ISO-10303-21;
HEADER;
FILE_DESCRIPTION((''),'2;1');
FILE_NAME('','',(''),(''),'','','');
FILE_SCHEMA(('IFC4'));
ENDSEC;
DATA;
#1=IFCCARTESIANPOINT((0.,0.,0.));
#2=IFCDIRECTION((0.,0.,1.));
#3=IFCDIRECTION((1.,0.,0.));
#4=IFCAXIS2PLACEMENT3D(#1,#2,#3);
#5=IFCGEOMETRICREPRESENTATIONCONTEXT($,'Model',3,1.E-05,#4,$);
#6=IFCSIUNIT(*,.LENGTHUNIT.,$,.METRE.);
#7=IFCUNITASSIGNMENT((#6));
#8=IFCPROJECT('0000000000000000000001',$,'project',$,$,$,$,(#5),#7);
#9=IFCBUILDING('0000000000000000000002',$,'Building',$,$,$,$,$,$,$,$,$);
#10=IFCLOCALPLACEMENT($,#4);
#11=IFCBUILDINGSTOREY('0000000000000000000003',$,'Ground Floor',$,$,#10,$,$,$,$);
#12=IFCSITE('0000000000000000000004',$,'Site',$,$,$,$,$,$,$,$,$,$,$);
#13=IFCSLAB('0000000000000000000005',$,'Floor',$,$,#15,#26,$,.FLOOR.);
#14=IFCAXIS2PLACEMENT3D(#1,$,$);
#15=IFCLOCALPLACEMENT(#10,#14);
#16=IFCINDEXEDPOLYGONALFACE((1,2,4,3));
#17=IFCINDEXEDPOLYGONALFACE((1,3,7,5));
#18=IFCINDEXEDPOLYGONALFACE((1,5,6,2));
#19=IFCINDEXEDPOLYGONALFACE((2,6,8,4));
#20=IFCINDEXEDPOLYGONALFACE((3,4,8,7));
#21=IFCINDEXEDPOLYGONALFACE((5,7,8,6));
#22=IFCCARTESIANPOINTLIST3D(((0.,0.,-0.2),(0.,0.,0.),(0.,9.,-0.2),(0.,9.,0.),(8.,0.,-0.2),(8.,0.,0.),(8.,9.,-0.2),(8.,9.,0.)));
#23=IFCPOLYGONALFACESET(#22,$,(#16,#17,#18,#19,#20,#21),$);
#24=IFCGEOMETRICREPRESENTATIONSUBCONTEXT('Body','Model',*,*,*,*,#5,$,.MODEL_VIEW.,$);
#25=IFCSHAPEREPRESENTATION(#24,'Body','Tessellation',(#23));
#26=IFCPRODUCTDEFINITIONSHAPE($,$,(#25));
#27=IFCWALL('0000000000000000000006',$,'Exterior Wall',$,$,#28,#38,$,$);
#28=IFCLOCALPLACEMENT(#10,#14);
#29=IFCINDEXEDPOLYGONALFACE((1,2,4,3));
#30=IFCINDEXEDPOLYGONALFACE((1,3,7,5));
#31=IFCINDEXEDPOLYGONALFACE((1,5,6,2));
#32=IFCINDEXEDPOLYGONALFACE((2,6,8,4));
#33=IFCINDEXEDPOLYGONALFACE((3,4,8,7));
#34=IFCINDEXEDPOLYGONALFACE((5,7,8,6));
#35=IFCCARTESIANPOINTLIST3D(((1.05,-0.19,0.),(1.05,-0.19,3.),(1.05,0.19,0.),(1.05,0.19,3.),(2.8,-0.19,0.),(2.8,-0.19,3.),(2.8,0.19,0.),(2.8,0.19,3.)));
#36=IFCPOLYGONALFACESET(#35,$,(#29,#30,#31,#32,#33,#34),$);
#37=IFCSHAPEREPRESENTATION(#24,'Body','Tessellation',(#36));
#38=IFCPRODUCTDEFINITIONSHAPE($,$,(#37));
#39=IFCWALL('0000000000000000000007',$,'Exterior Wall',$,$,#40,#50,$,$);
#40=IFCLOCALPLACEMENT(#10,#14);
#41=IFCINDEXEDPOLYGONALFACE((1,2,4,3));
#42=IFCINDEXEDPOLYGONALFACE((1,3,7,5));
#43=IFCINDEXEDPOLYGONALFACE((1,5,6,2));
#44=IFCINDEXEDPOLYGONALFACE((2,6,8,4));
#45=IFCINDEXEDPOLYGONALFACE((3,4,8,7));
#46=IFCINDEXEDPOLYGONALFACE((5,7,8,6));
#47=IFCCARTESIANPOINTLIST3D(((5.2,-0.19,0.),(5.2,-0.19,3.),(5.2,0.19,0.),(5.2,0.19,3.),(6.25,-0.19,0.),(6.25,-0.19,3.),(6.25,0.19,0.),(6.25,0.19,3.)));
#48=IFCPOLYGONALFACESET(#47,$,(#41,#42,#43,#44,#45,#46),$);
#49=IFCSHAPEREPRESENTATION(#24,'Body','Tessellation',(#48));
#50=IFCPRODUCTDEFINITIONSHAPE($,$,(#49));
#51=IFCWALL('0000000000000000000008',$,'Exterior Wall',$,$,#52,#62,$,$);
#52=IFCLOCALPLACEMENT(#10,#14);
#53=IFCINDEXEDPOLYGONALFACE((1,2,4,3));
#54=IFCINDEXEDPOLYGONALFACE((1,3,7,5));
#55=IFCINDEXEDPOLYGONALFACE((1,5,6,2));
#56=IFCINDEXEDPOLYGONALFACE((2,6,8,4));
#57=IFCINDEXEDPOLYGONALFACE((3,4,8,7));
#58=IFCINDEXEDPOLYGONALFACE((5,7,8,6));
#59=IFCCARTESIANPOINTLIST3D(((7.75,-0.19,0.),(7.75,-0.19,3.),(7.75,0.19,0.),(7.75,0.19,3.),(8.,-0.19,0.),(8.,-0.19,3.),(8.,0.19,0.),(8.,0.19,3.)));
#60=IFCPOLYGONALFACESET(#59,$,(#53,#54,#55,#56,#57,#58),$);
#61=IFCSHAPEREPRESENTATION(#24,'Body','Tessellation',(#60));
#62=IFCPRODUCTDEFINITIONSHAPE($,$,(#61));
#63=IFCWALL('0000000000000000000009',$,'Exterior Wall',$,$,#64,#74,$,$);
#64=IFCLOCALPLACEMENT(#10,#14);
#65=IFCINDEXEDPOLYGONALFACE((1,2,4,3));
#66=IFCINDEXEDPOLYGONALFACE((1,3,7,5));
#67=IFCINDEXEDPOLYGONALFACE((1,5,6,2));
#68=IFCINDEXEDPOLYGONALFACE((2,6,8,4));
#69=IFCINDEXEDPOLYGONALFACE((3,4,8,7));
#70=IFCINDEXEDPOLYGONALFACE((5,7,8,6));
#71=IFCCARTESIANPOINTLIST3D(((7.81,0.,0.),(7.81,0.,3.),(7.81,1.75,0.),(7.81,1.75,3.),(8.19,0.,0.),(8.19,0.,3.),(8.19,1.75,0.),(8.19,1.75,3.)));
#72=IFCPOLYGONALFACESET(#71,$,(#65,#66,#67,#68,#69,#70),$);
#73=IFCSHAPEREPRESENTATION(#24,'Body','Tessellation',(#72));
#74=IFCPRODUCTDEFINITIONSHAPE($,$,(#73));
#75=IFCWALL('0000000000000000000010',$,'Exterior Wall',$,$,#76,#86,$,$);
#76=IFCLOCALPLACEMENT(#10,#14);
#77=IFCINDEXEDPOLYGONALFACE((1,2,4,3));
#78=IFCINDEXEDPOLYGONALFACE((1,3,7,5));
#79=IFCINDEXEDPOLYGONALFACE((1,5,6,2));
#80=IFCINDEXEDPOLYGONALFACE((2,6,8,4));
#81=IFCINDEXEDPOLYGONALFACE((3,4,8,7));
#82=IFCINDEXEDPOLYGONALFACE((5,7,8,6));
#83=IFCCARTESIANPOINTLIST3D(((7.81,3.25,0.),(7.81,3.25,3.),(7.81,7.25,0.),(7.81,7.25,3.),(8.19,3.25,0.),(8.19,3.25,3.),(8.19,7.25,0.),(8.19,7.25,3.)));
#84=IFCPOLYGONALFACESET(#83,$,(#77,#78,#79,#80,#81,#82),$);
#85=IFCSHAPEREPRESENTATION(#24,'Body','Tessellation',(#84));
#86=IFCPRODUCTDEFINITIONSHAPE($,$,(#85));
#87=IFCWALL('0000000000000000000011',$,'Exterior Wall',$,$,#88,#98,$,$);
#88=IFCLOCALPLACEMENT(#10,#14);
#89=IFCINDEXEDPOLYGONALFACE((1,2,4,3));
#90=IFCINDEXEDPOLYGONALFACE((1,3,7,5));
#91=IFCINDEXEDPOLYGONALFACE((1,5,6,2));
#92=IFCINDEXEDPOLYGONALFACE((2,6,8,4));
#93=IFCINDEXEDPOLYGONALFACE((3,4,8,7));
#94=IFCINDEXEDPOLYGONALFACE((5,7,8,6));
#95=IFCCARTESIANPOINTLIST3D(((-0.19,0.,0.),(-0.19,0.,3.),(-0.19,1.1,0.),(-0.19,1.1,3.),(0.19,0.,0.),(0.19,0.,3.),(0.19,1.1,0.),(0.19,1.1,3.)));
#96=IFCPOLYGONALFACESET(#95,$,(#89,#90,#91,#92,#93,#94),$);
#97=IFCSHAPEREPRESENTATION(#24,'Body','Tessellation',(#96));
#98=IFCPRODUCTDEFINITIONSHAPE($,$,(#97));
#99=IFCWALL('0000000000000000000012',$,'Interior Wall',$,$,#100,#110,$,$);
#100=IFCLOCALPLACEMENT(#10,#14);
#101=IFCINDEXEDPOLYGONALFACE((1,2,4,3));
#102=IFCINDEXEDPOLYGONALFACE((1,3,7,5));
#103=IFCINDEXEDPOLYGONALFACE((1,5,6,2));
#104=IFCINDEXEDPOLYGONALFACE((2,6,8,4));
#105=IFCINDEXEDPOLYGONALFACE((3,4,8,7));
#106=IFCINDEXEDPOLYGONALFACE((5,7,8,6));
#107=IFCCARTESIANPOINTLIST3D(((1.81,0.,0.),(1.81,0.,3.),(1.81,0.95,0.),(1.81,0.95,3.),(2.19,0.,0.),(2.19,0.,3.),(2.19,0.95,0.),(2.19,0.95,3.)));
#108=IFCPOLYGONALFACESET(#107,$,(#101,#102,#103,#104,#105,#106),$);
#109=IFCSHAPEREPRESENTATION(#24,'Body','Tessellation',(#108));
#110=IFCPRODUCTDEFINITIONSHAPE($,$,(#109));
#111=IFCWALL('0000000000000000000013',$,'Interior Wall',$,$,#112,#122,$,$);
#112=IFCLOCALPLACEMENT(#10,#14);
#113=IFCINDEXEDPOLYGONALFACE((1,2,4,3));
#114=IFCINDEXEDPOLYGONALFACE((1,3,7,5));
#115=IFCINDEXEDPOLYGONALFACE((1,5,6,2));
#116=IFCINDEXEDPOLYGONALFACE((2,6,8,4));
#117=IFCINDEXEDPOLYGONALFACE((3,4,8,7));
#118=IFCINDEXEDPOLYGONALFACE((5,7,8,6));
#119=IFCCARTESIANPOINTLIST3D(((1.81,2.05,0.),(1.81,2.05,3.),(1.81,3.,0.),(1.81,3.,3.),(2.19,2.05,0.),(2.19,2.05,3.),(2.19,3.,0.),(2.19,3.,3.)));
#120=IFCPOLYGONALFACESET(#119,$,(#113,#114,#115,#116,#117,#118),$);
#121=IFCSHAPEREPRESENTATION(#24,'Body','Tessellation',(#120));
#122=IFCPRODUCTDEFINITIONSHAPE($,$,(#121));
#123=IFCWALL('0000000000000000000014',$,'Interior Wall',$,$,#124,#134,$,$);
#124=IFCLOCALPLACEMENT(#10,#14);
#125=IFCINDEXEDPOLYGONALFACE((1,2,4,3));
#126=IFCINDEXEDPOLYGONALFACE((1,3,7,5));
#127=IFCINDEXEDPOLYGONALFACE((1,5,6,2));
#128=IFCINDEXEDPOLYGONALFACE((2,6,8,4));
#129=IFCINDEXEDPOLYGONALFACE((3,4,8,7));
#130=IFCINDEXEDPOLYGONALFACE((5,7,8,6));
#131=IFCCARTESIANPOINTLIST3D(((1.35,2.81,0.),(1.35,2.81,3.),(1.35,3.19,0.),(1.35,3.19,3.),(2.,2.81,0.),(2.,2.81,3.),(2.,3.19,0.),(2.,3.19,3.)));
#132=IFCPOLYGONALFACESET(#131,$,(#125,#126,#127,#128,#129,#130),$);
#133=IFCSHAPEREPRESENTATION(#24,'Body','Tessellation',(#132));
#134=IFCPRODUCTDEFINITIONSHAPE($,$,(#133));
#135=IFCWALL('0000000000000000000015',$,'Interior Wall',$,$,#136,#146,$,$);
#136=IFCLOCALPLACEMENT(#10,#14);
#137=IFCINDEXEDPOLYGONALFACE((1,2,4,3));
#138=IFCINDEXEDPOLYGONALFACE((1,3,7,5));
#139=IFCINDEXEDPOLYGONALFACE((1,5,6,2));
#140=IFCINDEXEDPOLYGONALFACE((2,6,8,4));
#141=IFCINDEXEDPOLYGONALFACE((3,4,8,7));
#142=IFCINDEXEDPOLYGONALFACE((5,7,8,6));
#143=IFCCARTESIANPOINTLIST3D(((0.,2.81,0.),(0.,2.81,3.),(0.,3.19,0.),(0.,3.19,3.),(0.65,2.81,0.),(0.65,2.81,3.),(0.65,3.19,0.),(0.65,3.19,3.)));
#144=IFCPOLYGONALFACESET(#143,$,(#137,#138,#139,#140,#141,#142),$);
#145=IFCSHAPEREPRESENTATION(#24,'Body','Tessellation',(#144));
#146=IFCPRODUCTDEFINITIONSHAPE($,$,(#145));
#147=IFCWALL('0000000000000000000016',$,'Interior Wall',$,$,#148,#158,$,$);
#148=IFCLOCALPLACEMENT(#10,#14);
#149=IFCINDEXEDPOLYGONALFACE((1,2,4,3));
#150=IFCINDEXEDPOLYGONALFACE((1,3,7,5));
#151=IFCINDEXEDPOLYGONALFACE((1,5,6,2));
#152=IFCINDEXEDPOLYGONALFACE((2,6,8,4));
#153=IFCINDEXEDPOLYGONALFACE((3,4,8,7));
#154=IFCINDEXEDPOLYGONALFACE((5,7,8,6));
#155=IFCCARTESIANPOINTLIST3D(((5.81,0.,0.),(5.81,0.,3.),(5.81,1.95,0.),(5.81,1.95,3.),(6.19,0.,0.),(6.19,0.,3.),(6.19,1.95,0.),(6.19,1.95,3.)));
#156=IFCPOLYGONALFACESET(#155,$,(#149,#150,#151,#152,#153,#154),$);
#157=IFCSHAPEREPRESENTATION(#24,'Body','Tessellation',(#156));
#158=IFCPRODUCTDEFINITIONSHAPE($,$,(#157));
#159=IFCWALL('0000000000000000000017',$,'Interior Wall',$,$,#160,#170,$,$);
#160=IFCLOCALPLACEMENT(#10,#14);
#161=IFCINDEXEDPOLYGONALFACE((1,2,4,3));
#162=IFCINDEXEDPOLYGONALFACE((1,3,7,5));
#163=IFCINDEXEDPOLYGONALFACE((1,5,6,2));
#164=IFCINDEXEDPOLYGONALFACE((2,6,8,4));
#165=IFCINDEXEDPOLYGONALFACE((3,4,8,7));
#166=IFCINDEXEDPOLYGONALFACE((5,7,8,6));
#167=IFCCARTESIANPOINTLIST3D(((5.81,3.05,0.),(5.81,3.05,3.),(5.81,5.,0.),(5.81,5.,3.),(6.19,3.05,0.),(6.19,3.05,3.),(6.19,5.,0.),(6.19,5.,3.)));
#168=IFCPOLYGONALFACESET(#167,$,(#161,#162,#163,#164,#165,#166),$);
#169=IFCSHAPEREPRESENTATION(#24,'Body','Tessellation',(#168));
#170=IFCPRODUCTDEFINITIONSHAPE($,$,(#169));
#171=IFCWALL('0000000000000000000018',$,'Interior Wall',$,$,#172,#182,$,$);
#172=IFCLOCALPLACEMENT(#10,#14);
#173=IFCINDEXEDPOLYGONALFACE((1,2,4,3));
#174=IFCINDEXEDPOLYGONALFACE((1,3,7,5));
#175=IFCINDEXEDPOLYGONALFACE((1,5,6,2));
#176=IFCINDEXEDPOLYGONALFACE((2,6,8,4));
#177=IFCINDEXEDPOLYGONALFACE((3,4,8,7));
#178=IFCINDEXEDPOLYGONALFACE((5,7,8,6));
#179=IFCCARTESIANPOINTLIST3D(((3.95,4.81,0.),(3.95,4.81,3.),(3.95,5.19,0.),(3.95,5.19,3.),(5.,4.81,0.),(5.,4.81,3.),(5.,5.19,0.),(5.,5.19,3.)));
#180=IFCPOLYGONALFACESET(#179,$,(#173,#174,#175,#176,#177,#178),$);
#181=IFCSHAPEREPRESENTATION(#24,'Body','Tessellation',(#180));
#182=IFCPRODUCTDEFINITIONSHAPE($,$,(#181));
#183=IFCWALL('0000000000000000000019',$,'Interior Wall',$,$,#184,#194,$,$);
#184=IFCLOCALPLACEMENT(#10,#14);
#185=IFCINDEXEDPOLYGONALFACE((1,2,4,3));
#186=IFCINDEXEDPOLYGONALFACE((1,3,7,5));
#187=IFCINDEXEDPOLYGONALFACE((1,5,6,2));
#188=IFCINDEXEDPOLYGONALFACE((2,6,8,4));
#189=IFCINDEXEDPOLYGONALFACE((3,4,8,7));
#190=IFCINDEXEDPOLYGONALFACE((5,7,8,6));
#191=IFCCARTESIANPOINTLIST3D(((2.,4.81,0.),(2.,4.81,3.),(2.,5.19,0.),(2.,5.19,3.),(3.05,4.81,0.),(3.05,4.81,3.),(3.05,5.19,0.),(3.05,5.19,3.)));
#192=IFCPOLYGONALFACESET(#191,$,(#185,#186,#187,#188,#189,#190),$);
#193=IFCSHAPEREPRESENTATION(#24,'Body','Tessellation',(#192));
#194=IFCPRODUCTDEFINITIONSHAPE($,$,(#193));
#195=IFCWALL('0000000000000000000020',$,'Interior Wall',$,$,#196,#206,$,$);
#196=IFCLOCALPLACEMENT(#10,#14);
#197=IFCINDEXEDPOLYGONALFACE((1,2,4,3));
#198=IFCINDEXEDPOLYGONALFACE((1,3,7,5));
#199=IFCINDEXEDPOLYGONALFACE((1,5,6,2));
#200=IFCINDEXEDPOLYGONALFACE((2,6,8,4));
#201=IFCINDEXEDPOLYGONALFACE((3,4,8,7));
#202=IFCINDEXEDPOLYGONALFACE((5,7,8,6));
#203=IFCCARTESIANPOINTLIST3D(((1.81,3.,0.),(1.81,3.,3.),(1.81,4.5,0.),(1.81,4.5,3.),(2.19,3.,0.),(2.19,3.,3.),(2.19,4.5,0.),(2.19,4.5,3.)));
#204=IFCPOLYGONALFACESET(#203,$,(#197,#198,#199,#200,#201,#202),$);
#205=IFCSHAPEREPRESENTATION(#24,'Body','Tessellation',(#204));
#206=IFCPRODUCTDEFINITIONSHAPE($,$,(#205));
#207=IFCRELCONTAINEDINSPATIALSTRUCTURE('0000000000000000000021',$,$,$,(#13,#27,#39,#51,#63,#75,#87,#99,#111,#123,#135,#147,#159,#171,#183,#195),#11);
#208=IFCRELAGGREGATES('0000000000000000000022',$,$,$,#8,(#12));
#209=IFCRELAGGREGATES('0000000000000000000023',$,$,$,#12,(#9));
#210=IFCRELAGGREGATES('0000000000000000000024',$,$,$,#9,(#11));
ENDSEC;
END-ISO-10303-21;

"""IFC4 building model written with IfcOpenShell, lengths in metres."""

from ifc_helpers import new_model, si_unit, frame, origin_with_axes, place, context, subcontext, project, spatial, indexed_curve, outline, extrude, element, save


model = new_model("IFC4")

# Units and contexts
model_context = context("Model", 3, precision=1e-05, world=origin_with_axes())
body_context = subcontext(model_context, "Body", "Model", "MODEL_VIEW")
ifc_project = project(units=[si_unit("LENGTHUNIT", "METRE")], contexts=[model_context])

# Site, building, storey
site = spatial("IfcSite", under=ifc_project, Name="Site")
building = spatial("IfcBuilding", under=site, Name="Building")
storey_placement = place(None, origin_with_axes())
storey = spatial("IfcBuildingStorey", under=building, at=storey_placement, Name="Ground Floor")

# Slab
slab_placement = place(storey_placement, frame((0.0, 0.0, -0.2), z_axis=(0.0, 0.0, 1.0), x_axis=(1.0, 0.0, 0.0)))
element("IfcSlab", 1, at=slab_placement, inside=storey, Name="Floor", PredefinedType="FLOOR", context=body_context, shape_type="SweptSolid", body=[
    extrude(outline(indexed_curve([(0.0, 0.0), (8.0, 0.0), (8.0, 9.0), (0.0, 9.0)])), None, (0.0, 0.0, 1.0), 0.2),
])

# Walls
wall_1_placement = place(storey_placement, frame((1.05, 0.0, 0.0), z_axis=(0.0, 0.0, 1.0), x_axis=(1.0, 0.0, 0.0)))
element("IfcWall", 2, at=wall_1_placement, inside=storey, Name="Exterior Wall", context=body_context, shape_type="SweptSolid", body=[
    extrude(outline(indexed_curve([(0.0, 0.0), (0.0, 0.38), (1.75, 0.38), (1.75, 0.0), (0.0, 0.0)], self_intersect=False)), frame((0.0, -0.19, 0.0), z_axis=(0.0, 0.0, 1.0), x_axis=(1.0, 0.0, 0.0)), (0.0, 0.0, 1.0), 3.0),
])
wall_2_placement = place(storey_placement, frame((5.2, 0.0, 0.0), z_axis=(0.0, 0.0, 1.0), x_axis=(1.0, 0.0, 0.0)))
element("IfcWall", 3, at=wall_2_placement, inside=storey, Name="Exterior Wall", context=body_context, shape_type="SweptSolid", body=[
    extrude(outline(indexed_curve([(0.0, 0.0), (0.0, 0.38), (1.05, 0.38), (1.05, 0.0), (0.0, 0.0)], self_intersect=False)), frame((0.0, -0.19, 0.0), z_axis=(0.0, 0.0, 1.0), x_axis=(1.0, 0.0, 0.0)), (0.0, 0.0, 1.0), 3.0),
])
wall_3_placement = place(storey_placement, frame((7.75, 0.0, 0.0), z_axis=(0.0, 0.0, 1.0), x_axis=(1.0, 0.0, 0.0)))
element("IfcWall", 4, at=wall_3_placement, inside=storey, Name="Exterior Wall", context=body_context, shape_type="SweptSolid", body=[
    extrude(outline(indexed_curve([(0.0, 0.0), (0.0, 0.38), (0.25, 0.38), (0.25, 0.0), (0.0, 0.0)], self_intersect=False)), frame((0.0, -0.19, 0.0), z_axis=(0.0, 0.0, 1.0), x_axis=(1.0, 0.0, 0.0)), (0.0, 0.0, 1.0), 3.0),
])
wall_4_placement = place(storey_placement, frame((8.0, 0.0, 0.0), z_axis=(0.0, 0.0, 1.0), x_axis=(0.0, 1.0, 0.0)))
element("IfcWall", 5, at=wall_4_placement, inside=storey, Name="Exterior Wall", context=body_context, shape_type="SweptSolid", body=[
    extrude(outline(indexed_curve([(0.0, 0.0), (0.0, 0.38), (1.75, 0.38), (1.75, 0.0), (0.0, 0.0)], self_intersect=False)), frame((0.0, -0.19, 0.0), z_axis=(0.0, 0.0, 1.0), x_axis=(1.0, 0.0, 0.0)), (0.0, 0.0, 1.0), 3.0),
])
wall_5_placement = place(storey_placement, frame((8.0, 3.25, 0.0), z_axis=(0.0, 0.0, 1.0), x_axis=(0.0, 1.0, 0.0)))
element("IfcWall", 6, at=wall_5_placement, inside=storey, Name="Exterior Wall", context=body_context, shape_type="SweptSolid", body=[
    extrude(outline(indexed_curve([(0.0, 0.0), (0.0, 0.38), (4.0, 0.38), (4.0, 0.0), (0.0, 0.0)], self_intersect=False)), frame((0.0, -0.19, 0.0), z_axis=(0.0, 0.0, 1.0), x_axis=(1.0, 0.0, 0.0)), (0.0, 0.0, 1.0), 3.0),
])
wall_6_placement = place(storey_placement, frame((0.0, 1.1, 0.0), z_axis=(0.0, 0.0, 1.0), x_axis=(0.0, -1.0, 0.0)))
element("IfcWall", 7, at=wall_6_placement, inside=storey, Name="Exterior Wall", context=body_context, shape_type="SweptSolid", body=[
    extrude(outline(indexed_curve([(0.0, 0.0), (0.0, 0.38), (1.1, 0.38), (1.1, 0.0), (0.0, 0.0)], self_intersect=False)), frame((0.0, -0.19, 0.0), z_axis=(0.0, 0.0, 1.0), x_axis=(1.0, 0.0, 0.0)), (0.0, 0.0, 1.0), 3.0),
])
wall_7_placement = place(storey_placement, frame((2.0, 0.0, 0.0), z_axis=(0.0, 0.0, 1.0), x_axis=(0.0, 1.0, 0.0)))
element("IfcWall", 8, at=wall_7_placement, inside=storey, Name="Interior Wall", context=body_context, shape_type="SweptSolid", body=[
    extrude(outline(indexed_curve([(0.0, 0.0), (0.0, 0.38), (0.95, 0.38), (0.95, 0.0), (0.0, 0.0)], self_intersect=False)), frame((0.0, -0.19, 0.0), z_axis=(0.0, 0.0, 1.0), x_axis=(1.0, 0.0, 0.0)), (0.0, 0.0, 1.0), 3.0),
])
wall_8_placement = place(storey_placement, frame((2.0, 2.05, 0.0), z_axis=(0.0, 0.0, 1.0), x_axis=(0.0, 1.0, 0.0)))
element("IfcWall", 9, at=wall_8_placement, inside=storey, Name="Interior Wall", context=body_context, shape_type="SweptSolid", body=[
    extrude(outline(indexed_curve([(0.0, 0.0), (0.0, 0.38), (0.95, 0.38), (0.95, 0.0), (0.0, 0.0)], self_intersect=False)), frame((0.0, -0.19, 0.0), z_axis=(0.0, 0.0, 1.0), x_axis=(1.0, 0.0, 0.0)), (0.0, 0.0, 1.0), 3.0),
])
for number, where, z_axis, x_axis, name in (
    (10, (2.0, 3.0, 0.0), (0.0, 0.0, 1.0), (-1.0, 0.0, 0.0), "Interior Wall"),
    (11, (0.65, 3.0, 0.0), (0.0, 0.0, 1.0), (-1.0, 0.0, 0.0), "Interior Wall"),
):
    element("IfcWall", number, at=place(storey_placement, frame(where, z_axis=z_axis, x_axis=x_axis)), inside=storey, Name=name, context=body_context, shape_type="SweptSolid", body=[
        extrude(outline(indexed_curve([(0.0, 0.0), (0.0, 0.38), (0.65, 0.38), (0.65, 0.0), (0.0, 0.0)], self_intersect=False)), frame((0.0, -0.19, 0.0), z_axis=(0.0, 0.0, 1.0), x_axis=(1.0, 0.0, 0.0)), (0.0, 0.0, 1.0), 3.0),
    ])
wall_9_placement = place(storey_placement, frame((6.0, 0.0, 0.0), z_axis=(0.0, 0.0, 1.0), x_axis=(0.0, 1.0, 0.0)))
element("IfcWall", 12, at=wall_9_placement, inside=storey, Name="Interior Wall", context=body_context, shape_type="SweptSolid", body=[
    extrude(outline(indexed_curve([(0.0, 0.0), (0.0, 0.38), (1.95, 0.38), (1.95, 0.0), (0.0, 0.0)], self_intersect=False)), frame((0.0, -0.19, 0.0), z_axis=(0.0, 0.0, 1.0), x_axis=(1.0, 0.0, 0.0)), (0.0, 0.0, 1.0), 3.0),
])
wall_10_placement = place(storey_placement, frame((6.0, 3.05, 0.0), z_axis=(0.0, 0.0, 1.0), x_axis=(0.0, 1.0, 0.0)))
element("IfcWall", 13, at=wall_10_placement, inside=storey, Name="Interior Wall", context=body_context, shape_type="SweptSolid", body=[
    extrude(outline(indexed_curve([(0.0, 0.0), (0.0, 0.38), (1.95, 0.38), (1.95, 0.0), (0.0, 0.0)], self_intersect=False)), frame((0.0, -0.19, 0.0), z_axis=(0.0, 0.0, 1.0), x_axis=(1.0, 0.0, 0.0)), (0.0, 0.0, 1.0), 3.0),
])
for number, where, z_axis, x_axis, name in (
    (14, (5.0, 5.0, 0.0), (0.0, 0.0, 1.0), (-1.0, 0.0, 0.0), "Interior Wall"),
    (15, (3.05, 5.0, 0.0), (0.0, 0.0, 1.0), (-1.0, 0.0, 0.0), "Interior Wall"),
):
    element("IfcWall", number, at=place(storey_placement, frame(where, z_axis=z_axis, x_axis=x_axis)), inside=storey, Name=name, context=body_context, shape_type="SweptSolid", body=[
        extrude(outline(indexed_curve([(0.0, 0.0), (0.0, 0.38), (1.05, 0.38), (1.05, 0.0), (0.0, 0.0)], self_intersect=False)), frame((0.0, -0.19, 0.0), z_axis=(0.0, 0.0, 1.0), x_axis=(1.0, 0.0, 0.0)), (0.0, 0.0, 1.0), 3.0),
    ])
wall_11_placement = place(storey_placement, frame((2.0, 4.5, 0.0), z_axis=(0.0, 0.0, 1.0), x_axis=(0.0, -1.0, 0.0)))
element("IfcWall", 16, at=wall_11_placement, inside=storey, Name="Interior Wall", context=body_context, shape_type="SweptSolid", body=[
    extrude(outline(indexed_curve([(0.0, 0.0), (0.0, 0.38), (1.5, 0.38), (1.5, 0.0), (0.0, 0.0)], self_intersect=False)), frame((0.0, -0.19, 0.0), z_axis=(0.0, 0.0, 1.0), x_axis=(1.0, 0.0, 0.0)), (0.0, 0.0, 1.0), 3.0),
])

save(model, "model.ifc")
